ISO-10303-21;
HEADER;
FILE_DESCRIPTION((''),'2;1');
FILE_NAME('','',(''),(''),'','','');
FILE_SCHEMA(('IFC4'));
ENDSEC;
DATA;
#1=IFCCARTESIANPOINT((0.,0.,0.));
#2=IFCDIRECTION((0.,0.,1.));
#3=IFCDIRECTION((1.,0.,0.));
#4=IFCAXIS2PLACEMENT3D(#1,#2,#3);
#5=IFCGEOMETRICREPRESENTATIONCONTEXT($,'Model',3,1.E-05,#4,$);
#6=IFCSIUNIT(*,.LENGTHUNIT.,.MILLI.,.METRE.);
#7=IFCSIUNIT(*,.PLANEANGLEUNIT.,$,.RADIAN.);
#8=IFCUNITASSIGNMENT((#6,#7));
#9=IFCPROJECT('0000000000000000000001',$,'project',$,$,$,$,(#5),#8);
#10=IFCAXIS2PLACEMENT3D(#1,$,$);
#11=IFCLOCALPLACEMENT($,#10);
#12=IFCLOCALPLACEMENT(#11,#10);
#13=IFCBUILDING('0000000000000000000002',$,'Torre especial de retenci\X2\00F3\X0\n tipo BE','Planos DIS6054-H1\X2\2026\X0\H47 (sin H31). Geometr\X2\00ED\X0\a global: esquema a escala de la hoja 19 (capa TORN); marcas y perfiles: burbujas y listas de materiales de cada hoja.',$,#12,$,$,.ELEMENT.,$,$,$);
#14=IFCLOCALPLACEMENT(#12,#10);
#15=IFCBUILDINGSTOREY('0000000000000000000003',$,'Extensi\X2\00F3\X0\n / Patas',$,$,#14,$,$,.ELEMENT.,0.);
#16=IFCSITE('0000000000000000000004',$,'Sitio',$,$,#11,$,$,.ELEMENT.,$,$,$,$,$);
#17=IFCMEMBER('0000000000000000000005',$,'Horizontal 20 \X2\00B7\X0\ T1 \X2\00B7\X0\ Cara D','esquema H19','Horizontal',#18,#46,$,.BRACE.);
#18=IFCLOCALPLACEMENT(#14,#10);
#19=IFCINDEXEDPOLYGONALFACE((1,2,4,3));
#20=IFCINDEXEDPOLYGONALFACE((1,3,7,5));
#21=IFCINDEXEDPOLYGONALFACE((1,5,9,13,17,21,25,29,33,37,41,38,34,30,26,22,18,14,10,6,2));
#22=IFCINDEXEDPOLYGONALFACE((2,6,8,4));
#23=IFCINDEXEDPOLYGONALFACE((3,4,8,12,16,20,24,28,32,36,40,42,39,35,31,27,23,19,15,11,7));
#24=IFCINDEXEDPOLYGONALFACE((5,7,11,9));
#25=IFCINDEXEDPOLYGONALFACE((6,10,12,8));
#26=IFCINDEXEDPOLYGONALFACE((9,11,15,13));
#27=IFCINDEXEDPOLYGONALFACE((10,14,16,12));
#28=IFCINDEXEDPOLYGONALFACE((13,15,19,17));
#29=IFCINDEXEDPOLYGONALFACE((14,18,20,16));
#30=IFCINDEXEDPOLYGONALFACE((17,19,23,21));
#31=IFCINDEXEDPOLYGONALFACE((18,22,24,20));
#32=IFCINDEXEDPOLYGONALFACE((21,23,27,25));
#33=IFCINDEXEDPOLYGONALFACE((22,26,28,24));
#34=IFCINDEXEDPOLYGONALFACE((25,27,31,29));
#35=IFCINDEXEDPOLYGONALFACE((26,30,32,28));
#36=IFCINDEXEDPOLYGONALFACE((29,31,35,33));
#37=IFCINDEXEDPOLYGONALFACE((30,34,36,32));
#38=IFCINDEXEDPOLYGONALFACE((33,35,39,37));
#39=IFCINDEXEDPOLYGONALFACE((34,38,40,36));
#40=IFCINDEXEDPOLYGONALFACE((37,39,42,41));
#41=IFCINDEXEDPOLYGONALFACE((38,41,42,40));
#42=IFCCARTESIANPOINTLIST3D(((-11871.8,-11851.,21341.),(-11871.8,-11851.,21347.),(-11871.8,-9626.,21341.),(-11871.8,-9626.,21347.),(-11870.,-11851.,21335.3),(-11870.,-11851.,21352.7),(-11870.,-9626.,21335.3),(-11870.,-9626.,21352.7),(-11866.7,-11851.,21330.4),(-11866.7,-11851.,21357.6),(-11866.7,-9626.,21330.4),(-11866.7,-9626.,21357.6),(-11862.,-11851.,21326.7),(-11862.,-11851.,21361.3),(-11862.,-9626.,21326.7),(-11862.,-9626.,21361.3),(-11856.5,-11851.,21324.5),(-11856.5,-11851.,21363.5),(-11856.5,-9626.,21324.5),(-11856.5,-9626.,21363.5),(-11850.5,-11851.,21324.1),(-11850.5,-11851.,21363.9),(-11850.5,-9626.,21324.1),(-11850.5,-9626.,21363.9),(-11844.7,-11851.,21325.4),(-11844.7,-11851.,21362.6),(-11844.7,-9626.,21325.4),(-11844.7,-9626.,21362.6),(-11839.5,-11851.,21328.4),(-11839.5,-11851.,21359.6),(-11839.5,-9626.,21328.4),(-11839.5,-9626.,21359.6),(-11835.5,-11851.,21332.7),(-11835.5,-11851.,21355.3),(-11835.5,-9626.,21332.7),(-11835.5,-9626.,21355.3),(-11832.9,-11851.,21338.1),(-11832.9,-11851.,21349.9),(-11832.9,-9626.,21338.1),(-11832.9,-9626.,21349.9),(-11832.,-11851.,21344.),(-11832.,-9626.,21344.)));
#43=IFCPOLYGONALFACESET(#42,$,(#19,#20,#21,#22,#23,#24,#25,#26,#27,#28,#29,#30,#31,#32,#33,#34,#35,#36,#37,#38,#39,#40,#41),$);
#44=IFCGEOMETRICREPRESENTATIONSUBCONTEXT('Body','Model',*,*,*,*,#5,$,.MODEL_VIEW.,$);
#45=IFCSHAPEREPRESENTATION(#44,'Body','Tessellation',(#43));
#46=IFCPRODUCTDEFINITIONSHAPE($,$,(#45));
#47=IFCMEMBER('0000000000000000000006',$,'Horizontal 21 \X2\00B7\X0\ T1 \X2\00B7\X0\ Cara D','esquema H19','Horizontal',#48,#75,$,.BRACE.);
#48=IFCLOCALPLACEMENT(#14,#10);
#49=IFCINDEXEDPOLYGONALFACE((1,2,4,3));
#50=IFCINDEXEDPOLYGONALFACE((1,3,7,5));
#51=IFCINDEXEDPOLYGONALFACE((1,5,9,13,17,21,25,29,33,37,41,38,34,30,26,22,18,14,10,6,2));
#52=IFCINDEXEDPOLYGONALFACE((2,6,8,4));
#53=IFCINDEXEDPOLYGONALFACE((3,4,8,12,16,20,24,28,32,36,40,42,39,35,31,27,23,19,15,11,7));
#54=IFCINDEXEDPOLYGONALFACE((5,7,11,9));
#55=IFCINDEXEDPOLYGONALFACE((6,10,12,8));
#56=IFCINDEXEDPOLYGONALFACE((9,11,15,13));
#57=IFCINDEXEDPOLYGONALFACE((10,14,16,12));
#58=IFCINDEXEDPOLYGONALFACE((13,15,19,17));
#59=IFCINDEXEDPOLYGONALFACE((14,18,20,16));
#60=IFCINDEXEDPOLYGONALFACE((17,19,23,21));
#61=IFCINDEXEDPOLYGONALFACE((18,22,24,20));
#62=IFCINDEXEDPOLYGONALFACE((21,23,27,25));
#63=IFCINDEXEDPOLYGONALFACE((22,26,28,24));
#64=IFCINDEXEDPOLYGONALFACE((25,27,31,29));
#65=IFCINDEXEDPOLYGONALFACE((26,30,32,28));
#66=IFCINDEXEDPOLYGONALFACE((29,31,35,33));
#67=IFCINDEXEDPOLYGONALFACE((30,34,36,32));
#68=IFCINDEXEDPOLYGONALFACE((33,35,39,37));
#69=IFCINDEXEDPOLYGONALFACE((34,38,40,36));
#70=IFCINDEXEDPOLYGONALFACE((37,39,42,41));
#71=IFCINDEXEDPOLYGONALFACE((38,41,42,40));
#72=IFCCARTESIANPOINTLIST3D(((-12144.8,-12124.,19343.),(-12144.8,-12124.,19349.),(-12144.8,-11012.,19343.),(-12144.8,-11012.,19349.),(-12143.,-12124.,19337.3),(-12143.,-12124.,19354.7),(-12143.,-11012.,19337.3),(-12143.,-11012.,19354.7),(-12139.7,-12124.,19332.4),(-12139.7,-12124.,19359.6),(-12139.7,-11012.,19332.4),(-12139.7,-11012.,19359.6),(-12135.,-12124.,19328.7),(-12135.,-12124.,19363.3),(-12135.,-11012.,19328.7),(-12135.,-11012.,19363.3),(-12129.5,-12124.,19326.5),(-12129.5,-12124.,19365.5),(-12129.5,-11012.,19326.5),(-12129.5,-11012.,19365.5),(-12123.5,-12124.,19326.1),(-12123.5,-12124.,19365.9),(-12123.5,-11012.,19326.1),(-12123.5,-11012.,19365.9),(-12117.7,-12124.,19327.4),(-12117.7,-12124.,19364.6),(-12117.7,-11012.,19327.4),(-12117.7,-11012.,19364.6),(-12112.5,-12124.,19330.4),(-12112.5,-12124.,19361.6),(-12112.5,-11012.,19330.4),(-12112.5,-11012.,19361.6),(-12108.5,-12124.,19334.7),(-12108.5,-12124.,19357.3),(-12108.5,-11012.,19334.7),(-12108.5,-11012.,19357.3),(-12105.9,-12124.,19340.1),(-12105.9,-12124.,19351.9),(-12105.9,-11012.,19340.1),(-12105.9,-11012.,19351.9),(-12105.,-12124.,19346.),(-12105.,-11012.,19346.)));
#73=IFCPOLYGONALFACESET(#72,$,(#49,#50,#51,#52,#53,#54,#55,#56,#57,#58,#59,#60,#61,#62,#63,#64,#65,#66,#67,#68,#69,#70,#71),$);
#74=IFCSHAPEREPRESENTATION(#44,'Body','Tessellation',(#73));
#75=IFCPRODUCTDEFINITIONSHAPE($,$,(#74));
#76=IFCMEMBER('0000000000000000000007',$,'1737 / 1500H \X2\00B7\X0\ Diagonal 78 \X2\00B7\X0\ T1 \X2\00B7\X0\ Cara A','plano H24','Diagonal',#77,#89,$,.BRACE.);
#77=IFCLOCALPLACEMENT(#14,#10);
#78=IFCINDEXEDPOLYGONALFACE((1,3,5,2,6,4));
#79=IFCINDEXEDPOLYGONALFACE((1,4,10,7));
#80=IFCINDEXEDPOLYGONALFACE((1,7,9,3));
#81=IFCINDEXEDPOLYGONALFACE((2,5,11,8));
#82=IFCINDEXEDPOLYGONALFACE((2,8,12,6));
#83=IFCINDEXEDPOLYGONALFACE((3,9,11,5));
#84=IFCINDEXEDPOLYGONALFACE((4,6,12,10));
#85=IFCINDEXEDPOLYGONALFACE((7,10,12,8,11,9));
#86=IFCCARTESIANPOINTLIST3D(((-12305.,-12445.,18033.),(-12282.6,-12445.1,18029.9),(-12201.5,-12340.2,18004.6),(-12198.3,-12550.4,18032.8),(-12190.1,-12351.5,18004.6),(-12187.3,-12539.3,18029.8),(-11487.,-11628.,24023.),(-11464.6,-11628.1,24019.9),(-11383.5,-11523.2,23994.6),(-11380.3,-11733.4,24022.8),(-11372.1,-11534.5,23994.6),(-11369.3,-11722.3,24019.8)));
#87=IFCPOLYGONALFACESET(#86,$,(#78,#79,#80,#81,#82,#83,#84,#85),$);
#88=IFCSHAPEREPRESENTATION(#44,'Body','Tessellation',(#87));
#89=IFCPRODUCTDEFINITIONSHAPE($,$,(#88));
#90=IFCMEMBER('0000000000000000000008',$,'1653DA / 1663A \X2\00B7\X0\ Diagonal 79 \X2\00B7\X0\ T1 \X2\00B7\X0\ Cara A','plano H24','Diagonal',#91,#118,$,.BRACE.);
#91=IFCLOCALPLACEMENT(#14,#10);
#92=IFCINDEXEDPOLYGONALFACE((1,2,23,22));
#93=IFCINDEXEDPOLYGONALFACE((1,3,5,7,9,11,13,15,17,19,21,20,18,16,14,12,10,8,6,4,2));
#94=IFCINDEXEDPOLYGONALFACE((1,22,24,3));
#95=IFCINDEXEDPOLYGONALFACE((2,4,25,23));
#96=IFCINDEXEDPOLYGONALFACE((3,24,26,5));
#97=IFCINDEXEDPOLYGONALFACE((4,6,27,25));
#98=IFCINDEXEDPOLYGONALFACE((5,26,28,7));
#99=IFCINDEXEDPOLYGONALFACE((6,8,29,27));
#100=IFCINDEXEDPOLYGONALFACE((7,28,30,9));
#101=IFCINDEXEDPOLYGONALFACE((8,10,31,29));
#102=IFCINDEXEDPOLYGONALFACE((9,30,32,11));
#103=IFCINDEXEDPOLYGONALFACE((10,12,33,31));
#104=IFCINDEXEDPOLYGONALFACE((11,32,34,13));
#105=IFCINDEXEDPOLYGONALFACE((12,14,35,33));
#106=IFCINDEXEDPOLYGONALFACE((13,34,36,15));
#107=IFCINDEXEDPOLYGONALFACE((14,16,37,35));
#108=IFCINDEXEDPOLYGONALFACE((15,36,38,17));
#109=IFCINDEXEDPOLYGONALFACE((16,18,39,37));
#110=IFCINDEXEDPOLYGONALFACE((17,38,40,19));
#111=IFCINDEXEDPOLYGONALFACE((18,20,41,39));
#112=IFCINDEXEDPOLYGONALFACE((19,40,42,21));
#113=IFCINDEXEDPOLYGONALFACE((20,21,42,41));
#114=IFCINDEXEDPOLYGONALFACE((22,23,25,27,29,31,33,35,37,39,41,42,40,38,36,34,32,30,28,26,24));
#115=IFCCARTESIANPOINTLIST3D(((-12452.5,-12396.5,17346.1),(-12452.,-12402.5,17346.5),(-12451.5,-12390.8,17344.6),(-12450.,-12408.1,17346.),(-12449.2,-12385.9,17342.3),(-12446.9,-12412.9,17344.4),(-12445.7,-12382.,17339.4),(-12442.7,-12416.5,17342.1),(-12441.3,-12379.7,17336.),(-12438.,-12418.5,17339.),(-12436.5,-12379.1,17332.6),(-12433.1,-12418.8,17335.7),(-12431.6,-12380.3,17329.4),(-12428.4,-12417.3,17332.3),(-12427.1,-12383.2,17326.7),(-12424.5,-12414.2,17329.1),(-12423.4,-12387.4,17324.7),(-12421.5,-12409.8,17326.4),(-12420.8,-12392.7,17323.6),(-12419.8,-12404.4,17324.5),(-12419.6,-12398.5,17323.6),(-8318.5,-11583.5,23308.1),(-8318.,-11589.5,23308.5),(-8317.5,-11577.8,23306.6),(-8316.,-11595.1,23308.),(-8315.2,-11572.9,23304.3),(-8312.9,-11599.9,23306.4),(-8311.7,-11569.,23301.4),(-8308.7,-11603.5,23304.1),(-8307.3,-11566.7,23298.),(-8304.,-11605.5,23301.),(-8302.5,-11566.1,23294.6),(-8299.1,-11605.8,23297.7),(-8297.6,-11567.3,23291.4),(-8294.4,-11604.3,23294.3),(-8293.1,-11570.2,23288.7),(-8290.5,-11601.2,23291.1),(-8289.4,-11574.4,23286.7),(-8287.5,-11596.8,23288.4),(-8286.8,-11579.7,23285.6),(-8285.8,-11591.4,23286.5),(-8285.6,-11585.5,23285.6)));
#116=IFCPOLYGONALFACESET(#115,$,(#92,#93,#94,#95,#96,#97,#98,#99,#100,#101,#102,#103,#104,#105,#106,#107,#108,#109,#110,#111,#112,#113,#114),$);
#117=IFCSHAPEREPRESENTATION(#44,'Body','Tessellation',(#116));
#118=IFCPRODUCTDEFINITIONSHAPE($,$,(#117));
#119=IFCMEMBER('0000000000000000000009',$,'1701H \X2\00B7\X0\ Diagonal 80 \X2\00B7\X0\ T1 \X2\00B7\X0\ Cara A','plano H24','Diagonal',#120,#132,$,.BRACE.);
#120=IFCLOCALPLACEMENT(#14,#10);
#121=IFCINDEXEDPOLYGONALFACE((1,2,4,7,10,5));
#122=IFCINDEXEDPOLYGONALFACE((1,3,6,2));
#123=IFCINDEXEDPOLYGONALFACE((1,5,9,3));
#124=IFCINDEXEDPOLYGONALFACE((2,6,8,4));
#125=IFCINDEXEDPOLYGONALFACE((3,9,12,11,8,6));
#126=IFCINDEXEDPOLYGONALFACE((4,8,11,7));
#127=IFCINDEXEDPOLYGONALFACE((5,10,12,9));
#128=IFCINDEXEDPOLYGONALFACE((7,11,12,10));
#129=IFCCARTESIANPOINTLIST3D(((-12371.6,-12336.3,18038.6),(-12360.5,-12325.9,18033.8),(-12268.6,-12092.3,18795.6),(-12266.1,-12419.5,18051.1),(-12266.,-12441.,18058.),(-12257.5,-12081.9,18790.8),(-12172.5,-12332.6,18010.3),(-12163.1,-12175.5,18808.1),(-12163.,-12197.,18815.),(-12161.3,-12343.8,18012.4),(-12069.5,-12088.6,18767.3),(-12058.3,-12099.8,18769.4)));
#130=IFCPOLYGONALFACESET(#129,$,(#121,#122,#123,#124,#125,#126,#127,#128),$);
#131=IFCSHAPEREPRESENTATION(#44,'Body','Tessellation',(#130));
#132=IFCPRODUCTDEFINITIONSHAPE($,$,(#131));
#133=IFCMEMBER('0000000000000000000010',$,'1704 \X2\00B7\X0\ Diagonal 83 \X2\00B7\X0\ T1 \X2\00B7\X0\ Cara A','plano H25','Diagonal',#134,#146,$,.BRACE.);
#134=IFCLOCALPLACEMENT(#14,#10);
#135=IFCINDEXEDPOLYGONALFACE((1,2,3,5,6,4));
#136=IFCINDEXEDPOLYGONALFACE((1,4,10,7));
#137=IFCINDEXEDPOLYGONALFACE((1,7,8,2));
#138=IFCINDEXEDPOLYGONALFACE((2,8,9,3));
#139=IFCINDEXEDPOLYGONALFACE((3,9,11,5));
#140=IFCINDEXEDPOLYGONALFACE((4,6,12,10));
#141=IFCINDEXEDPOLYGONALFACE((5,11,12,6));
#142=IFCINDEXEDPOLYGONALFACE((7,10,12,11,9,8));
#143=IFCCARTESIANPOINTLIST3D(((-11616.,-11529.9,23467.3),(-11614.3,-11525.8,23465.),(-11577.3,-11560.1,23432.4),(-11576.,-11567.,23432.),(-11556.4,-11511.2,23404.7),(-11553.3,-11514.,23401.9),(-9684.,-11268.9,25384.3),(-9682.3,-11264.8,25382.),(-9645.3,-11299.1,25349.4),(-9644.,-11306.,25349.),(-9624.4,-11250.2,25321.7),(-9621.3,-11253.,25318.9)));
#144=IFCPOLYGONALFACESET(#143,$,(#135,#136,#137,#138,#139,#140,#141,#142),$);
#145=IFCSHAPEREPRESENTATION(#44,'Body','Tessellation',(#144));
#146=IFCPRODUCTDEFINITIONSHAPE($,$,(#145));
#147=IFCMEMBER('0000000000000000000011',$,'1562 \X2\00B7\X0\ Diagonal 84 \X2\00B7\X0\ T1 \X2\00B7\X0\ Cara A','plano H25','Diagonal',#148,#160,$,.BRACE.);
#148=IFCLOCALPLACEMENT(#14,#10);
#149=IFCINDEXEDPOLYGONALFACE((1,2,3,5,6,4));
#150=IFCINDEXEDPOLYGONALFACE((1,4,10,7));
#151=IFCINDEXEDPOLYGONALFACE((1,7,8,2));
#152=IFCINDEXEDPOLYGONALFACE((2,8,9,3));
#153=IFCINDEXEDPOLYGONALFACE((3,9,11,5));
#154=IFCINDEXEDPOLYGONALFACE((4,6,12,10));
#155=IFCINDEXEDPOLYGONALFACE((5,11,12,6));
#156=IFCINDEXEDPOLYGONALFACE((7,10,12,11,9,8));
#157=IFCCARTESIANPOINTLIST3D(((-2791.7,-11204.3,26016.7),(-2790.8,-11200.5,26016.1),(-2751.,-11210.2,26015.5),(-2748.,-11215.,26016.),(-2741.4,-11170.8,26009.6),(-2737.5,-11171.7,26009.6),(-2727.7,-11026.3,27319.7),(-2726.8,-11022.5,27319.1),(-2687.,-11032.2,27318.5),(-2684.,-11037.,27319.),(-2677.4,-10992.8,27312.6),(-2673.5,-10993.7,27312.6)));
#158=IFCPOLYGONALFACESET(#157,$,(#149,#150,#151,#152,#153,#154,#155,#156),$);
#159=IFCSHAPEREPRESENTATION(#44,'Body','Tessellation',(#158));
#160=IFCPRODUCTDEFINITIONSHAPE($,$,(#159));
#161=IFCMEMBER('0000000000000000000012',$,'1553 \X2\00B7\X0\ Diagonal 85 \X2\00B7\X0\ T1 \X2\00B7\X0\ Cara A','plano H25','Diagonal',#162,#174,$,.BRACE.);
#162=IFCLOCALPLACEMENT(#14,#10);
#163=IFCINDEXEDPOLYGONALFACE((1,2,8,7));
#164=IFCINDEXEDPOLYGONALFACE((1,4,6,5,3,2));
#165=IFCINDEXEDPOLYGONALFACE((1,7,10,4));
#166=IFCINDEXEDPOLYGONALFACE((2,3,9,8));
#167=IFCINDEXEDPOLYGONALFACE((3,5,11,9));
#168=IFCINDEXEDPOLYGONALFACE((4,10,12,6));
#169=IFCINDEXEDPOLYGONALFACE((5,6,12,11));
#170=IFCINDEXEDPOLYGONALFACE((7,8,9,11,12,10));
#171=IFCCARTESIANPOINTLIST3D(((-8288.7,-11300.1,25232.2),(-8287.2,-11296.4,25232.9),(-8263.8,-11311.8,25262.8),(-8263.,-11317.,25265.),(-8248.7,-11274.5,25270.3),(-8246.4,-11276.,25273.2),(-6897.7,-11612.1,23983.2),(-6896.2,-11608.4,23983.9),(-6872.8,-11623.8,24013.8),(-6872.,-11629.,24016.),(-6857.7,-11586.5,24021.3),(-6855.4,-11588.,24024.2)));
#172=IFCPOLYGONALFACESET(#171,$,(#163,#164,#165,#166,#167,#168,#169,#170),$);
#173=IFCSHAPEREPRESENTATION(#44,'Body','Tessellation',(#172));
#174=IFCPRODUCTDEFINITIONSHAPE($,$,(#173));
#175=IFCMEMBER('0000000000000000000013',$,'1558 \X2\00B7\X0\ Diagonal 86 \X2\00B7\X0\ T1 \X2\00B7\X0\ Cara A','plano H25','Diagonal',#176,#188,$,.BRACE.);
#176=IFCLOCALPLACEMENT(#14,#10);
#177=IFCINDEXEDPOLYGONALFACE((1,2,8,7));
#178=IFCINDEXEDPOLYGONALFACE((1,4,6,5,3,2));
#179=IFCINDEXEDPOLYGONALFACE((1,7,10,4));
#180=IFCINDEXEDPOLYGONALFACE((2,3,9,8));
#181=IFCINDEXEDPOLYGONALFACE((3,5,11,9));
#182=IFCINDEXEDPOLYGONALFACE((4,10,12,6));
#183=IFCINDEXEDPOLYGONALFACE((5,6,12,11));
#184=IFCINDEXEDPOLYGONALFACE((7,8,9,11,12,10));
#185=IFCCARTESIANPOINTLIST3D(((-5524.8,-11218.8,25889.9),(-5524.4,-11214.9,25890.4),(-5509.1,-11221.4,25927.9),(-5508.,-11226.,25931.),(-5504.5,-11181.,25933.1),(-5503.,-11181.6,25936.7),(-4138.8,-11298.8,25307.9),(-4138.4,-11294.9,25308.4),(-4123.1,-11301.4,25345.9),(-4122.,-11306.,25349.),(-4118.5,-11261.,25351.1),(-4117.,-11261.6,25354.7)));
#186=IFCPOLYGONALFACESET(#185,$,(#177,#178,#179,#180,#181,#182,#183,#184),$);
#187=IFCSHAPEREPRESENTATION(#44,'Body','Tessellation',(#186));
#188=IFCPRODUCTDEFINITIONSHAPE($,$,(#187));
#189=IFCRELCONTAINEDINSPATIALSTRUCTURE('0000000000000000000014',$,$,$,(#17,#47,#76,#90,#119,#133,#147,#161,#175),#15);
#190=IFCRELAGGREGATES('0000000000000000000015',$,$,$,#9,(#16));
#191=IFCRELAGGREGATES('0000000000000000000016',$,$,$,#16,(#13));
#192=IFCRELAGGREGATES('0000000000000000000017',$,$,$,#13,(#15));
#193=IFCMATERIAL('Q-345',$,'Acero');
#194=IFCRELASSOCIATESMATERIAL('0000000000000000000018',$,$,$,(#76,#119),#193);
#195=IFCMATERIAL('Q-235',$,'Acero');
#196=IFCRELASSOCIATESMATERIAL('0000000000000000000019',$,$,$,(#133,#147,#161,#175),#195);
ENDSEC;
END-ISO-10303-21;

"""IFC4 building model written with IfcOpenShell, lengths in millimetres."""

from ifc_helpers import new_model, si_unit, frame, frame_2d, origin, origin_with_axes, place, context, subcontext, project, spatial, circle, l_section, extrude, material, element, save


model = new_model("IFC4")

# Units and contexts
model_context = context("Model", 3, precision=1e-05, world=origin_with_axes())
body_context = subcontext(model_context, "Body", "Model", "MODEL_VIEW")
ifc_project = project(units=[si_unit("LENGTHUNIT", "METRE", prefix="MILLI"), si_unit("PLANEANGLEUNIT", "RADIAN")], contexts=[model_context])

# Site, building, storey
site_placement = place(None, origin())
site = spatial("IfcSite", under=ifc_project, at=site_placement, Name="Sitio", CompositionType="ELEMENT")
building_placement = place(site_placement, origin())
building = spatial("IfcBuilding", under=site, at=building_placement, Name="Torre especial de retención tipo BE", Description="Planos DIS6054-H1…H47 (sin H31). Geometría global: esquema a escala de la hoja 19 (capa TORN); marcas y perfiles: burbujas y listas de materiales de cada hoja.", CompositionType="ELEMENT")
storey_placement = place(building_placement, origin())
storey = spatial("IfcBuildingStorey", under=building, at=storey_placement, Name="Extensión / Patas", CompositionType="ELEMENT", Elevation=0.0)

# Members
ifc_material_1 = material(Name="Q-235", Category="Acero")
member_1_placement = place(storey_placement, frame((-11852.0, -11851.0, 21344.0), z_axis=(0.0, 1.0, 0.0), x_axis=(1.0, 0.0, 0.0)))
element("IfcMember", 1, at=member_1_placement, inside=storey, Name="Horizontal 20 · T1 · Cara D", Description="esquema H19", ObjectType="Horizontal", PredefinedType="BRACE", context=body_context, shape_type="SweptSolid", body=[
    extrude(circle(Radius=20.0), None, (0.0, 0.0, 1.0), 2225.0),
])
member_2_placement = place(storey_placement, frame((-12125.0, -12124.0, 19346.0), z_axis=(0.0, 1.0, 0.0), x_axis=(1.0, 0.0, 0.0)))
element("IfcMember", 2, at=member_2_placement, inside=storey, Name="Horizontal 21 · T1 · Cara D", Description="esquema H19", ObjectType="Horizontal", PredefinedType="BRACE", context=body_context, shape_type="SweptSolid", body=[
    extrude(circle(Radius=20.0), None, (0.0, 0.0, 1.0), 1112.0),
])
ifc_material_2 = material(Name="Q-345", Category="Acero")
member_3_placement = place(storey_placement, frame((-11487.0, -11628.0, 24023.0), z_axis=(-0.134086, -0.133922, -0.981879), x_axis=(0.690037, 0.698524, -0.189507)))
element("IfcMember", 3, at=member_3_placement, inside=storey, material=ifc_material_2, Name="1737 / 1500H · Diagonal 78 · T1 · Cara A", Description="plano H24", ObjectType="Diagonal", PredefinedType="BRACE", context=body_context, shape_type="SweptSolid", body=[
    extrude(l_section(Depth=150.0, Width=150.0, Thickness=16.0, at=frame_2d((75.0, 75.0))), None, (0.0, 0.0, 1.0), 6100.6),
])
member_4_placement = place(storey_placement, frame((-8302.0, -11586.0, 23297.0), z_axis=(-0.566268, -0.111363, -0.816664), x_axis=(0.445292, 0.792448, -0.416823)))
element("IfcMember", 4, at=member_4_placement, inside=storey, Name="1653DA / 1663A · Diagonal 79 · T1 · Cara A", Description="plano H24", ObjectType="Diagonal", PredefinedType="BRACE", context=body_context, shape_type="SweptSolid", body=[
    extrude(circle(Radius=20.0), None, (0.0, 0.0, 1.0), 7300.4),
])
member_5_placement = place(storey_placement, frame((-12266.0, -12441.0, 18058.0), z_axis=(0.12843, 0.304242, 0.943898), x_axis=(0.698332, 0.648055, -0.303902)))
element("IfcMember", 5, at=member_5_placement, inside=storey, material=ifc_material_2, Name="1701H · Diagonal 80 · T1 · Cara A", Description="plano H24", ObjectType="Diagonal", PredefinedType="BRACE", context=body_context, shape_type="SweptSolid", body=[
    extrude(l_section(Depth=150.0, Width=150.0, Thickness=16.0, at=frame_2d((75.0, 75.0))), None, (0.0, 0.0, 1.0), 802.0),
])
member_6_placement = place(storey_placement, frame((-11576.0, -11567.0, 23432.0), z_axis=(0.706615, 0.095459, 0.701129), x_axis=(0.348689, 0.815225, -0.46241)))
element("IfcMember", 6, at=member_6_placement, inside=storey, material=ifc_material_1, Name="1704 · Diagonal 83 · T1 · Cara A", Description="plano H25", ObjectType="Diagonal", PredefinedType="BRACE", context=body_context, shape_type="SweptSolid", body=[
    extrude(l_section(Depth=65.0, Width=65.0, Thickness=5.0, at=frame_2d((32.5, 32.5))), None, (0.0, 0.0, 1.0), 2734.2),
])
member_7_placement = place(storey_placement, frame((-2748.0, -11215.0, 26016.0), z_axis=(0.048608, 0.135191, 0.989627), x_axis=(0.232591, 0.962028, -0.142845)))
element("IfcMember", 7, at=member_7_placement, inside=storey, material=ifc_material_1, Name="1562 · Diagonal 84 · T1 · Cara A", Description="plano H25", ObjectType="Diagonal", PredefinedType="BRACE", context=body_context, shape_type="SweptSolid", body=[
    extrude(l_section(Depth=45.0, Width=45.0, Thickness=4.0, at=frame_2d((22.5, 22.5))), None, (0.0, 0.0, 1.0), 1316.7),
])
member_8_placement = place(storey_placement, frame((-6872.0, -11629.0, 24016.0), z_axis=(-0.733914, 0.164616, 0.658993), x_axis=(0.368219, 0.911683, 0.182344)))
element("IfcMember", 8, at=member_8_placement, inside=storey, material=ifc_material_1, Name="1553 · Diagonal 85 · T1 · Cara A", Description="plano H25", ObjectType="Diagonal", PredefinedType="BRACE", context=body_context, shape_type="SweptSolid", body=[
    extrude(l_section(Depth=45.0, Width=45.0, Thickness=4.0, at=frame_2d((22.5, 22.5))), None, (0.0, 0.0, 1.0), 1895.3),
])
member_9_placement = place(storey_placement, frame((-4122.0, -11306.0, 25349.0), z_axis=(-0.920708, 0.053143, 0.386618), x_axis=(0.110392, 0.985689, 0.127402)))
element("IfcMember", 9, at=member_9_placement, inside=storey, material=ifc_material_1, Name="1558 · Diagonal 86 · T1 · Cara A", Description="plano H25", ObjectType="Diagonal", PredefinedType="BRACE", context=body_context, shape_type="SweptSolid", body=[
    extrude(l_section(Depth=45.0, Width=45.0, Thickness=4.0, at=frame_2d((22.5, 22.5))), None, (0.0, 0.0, 1.0), 1505.4),
])

save(model, "model.ifc")
